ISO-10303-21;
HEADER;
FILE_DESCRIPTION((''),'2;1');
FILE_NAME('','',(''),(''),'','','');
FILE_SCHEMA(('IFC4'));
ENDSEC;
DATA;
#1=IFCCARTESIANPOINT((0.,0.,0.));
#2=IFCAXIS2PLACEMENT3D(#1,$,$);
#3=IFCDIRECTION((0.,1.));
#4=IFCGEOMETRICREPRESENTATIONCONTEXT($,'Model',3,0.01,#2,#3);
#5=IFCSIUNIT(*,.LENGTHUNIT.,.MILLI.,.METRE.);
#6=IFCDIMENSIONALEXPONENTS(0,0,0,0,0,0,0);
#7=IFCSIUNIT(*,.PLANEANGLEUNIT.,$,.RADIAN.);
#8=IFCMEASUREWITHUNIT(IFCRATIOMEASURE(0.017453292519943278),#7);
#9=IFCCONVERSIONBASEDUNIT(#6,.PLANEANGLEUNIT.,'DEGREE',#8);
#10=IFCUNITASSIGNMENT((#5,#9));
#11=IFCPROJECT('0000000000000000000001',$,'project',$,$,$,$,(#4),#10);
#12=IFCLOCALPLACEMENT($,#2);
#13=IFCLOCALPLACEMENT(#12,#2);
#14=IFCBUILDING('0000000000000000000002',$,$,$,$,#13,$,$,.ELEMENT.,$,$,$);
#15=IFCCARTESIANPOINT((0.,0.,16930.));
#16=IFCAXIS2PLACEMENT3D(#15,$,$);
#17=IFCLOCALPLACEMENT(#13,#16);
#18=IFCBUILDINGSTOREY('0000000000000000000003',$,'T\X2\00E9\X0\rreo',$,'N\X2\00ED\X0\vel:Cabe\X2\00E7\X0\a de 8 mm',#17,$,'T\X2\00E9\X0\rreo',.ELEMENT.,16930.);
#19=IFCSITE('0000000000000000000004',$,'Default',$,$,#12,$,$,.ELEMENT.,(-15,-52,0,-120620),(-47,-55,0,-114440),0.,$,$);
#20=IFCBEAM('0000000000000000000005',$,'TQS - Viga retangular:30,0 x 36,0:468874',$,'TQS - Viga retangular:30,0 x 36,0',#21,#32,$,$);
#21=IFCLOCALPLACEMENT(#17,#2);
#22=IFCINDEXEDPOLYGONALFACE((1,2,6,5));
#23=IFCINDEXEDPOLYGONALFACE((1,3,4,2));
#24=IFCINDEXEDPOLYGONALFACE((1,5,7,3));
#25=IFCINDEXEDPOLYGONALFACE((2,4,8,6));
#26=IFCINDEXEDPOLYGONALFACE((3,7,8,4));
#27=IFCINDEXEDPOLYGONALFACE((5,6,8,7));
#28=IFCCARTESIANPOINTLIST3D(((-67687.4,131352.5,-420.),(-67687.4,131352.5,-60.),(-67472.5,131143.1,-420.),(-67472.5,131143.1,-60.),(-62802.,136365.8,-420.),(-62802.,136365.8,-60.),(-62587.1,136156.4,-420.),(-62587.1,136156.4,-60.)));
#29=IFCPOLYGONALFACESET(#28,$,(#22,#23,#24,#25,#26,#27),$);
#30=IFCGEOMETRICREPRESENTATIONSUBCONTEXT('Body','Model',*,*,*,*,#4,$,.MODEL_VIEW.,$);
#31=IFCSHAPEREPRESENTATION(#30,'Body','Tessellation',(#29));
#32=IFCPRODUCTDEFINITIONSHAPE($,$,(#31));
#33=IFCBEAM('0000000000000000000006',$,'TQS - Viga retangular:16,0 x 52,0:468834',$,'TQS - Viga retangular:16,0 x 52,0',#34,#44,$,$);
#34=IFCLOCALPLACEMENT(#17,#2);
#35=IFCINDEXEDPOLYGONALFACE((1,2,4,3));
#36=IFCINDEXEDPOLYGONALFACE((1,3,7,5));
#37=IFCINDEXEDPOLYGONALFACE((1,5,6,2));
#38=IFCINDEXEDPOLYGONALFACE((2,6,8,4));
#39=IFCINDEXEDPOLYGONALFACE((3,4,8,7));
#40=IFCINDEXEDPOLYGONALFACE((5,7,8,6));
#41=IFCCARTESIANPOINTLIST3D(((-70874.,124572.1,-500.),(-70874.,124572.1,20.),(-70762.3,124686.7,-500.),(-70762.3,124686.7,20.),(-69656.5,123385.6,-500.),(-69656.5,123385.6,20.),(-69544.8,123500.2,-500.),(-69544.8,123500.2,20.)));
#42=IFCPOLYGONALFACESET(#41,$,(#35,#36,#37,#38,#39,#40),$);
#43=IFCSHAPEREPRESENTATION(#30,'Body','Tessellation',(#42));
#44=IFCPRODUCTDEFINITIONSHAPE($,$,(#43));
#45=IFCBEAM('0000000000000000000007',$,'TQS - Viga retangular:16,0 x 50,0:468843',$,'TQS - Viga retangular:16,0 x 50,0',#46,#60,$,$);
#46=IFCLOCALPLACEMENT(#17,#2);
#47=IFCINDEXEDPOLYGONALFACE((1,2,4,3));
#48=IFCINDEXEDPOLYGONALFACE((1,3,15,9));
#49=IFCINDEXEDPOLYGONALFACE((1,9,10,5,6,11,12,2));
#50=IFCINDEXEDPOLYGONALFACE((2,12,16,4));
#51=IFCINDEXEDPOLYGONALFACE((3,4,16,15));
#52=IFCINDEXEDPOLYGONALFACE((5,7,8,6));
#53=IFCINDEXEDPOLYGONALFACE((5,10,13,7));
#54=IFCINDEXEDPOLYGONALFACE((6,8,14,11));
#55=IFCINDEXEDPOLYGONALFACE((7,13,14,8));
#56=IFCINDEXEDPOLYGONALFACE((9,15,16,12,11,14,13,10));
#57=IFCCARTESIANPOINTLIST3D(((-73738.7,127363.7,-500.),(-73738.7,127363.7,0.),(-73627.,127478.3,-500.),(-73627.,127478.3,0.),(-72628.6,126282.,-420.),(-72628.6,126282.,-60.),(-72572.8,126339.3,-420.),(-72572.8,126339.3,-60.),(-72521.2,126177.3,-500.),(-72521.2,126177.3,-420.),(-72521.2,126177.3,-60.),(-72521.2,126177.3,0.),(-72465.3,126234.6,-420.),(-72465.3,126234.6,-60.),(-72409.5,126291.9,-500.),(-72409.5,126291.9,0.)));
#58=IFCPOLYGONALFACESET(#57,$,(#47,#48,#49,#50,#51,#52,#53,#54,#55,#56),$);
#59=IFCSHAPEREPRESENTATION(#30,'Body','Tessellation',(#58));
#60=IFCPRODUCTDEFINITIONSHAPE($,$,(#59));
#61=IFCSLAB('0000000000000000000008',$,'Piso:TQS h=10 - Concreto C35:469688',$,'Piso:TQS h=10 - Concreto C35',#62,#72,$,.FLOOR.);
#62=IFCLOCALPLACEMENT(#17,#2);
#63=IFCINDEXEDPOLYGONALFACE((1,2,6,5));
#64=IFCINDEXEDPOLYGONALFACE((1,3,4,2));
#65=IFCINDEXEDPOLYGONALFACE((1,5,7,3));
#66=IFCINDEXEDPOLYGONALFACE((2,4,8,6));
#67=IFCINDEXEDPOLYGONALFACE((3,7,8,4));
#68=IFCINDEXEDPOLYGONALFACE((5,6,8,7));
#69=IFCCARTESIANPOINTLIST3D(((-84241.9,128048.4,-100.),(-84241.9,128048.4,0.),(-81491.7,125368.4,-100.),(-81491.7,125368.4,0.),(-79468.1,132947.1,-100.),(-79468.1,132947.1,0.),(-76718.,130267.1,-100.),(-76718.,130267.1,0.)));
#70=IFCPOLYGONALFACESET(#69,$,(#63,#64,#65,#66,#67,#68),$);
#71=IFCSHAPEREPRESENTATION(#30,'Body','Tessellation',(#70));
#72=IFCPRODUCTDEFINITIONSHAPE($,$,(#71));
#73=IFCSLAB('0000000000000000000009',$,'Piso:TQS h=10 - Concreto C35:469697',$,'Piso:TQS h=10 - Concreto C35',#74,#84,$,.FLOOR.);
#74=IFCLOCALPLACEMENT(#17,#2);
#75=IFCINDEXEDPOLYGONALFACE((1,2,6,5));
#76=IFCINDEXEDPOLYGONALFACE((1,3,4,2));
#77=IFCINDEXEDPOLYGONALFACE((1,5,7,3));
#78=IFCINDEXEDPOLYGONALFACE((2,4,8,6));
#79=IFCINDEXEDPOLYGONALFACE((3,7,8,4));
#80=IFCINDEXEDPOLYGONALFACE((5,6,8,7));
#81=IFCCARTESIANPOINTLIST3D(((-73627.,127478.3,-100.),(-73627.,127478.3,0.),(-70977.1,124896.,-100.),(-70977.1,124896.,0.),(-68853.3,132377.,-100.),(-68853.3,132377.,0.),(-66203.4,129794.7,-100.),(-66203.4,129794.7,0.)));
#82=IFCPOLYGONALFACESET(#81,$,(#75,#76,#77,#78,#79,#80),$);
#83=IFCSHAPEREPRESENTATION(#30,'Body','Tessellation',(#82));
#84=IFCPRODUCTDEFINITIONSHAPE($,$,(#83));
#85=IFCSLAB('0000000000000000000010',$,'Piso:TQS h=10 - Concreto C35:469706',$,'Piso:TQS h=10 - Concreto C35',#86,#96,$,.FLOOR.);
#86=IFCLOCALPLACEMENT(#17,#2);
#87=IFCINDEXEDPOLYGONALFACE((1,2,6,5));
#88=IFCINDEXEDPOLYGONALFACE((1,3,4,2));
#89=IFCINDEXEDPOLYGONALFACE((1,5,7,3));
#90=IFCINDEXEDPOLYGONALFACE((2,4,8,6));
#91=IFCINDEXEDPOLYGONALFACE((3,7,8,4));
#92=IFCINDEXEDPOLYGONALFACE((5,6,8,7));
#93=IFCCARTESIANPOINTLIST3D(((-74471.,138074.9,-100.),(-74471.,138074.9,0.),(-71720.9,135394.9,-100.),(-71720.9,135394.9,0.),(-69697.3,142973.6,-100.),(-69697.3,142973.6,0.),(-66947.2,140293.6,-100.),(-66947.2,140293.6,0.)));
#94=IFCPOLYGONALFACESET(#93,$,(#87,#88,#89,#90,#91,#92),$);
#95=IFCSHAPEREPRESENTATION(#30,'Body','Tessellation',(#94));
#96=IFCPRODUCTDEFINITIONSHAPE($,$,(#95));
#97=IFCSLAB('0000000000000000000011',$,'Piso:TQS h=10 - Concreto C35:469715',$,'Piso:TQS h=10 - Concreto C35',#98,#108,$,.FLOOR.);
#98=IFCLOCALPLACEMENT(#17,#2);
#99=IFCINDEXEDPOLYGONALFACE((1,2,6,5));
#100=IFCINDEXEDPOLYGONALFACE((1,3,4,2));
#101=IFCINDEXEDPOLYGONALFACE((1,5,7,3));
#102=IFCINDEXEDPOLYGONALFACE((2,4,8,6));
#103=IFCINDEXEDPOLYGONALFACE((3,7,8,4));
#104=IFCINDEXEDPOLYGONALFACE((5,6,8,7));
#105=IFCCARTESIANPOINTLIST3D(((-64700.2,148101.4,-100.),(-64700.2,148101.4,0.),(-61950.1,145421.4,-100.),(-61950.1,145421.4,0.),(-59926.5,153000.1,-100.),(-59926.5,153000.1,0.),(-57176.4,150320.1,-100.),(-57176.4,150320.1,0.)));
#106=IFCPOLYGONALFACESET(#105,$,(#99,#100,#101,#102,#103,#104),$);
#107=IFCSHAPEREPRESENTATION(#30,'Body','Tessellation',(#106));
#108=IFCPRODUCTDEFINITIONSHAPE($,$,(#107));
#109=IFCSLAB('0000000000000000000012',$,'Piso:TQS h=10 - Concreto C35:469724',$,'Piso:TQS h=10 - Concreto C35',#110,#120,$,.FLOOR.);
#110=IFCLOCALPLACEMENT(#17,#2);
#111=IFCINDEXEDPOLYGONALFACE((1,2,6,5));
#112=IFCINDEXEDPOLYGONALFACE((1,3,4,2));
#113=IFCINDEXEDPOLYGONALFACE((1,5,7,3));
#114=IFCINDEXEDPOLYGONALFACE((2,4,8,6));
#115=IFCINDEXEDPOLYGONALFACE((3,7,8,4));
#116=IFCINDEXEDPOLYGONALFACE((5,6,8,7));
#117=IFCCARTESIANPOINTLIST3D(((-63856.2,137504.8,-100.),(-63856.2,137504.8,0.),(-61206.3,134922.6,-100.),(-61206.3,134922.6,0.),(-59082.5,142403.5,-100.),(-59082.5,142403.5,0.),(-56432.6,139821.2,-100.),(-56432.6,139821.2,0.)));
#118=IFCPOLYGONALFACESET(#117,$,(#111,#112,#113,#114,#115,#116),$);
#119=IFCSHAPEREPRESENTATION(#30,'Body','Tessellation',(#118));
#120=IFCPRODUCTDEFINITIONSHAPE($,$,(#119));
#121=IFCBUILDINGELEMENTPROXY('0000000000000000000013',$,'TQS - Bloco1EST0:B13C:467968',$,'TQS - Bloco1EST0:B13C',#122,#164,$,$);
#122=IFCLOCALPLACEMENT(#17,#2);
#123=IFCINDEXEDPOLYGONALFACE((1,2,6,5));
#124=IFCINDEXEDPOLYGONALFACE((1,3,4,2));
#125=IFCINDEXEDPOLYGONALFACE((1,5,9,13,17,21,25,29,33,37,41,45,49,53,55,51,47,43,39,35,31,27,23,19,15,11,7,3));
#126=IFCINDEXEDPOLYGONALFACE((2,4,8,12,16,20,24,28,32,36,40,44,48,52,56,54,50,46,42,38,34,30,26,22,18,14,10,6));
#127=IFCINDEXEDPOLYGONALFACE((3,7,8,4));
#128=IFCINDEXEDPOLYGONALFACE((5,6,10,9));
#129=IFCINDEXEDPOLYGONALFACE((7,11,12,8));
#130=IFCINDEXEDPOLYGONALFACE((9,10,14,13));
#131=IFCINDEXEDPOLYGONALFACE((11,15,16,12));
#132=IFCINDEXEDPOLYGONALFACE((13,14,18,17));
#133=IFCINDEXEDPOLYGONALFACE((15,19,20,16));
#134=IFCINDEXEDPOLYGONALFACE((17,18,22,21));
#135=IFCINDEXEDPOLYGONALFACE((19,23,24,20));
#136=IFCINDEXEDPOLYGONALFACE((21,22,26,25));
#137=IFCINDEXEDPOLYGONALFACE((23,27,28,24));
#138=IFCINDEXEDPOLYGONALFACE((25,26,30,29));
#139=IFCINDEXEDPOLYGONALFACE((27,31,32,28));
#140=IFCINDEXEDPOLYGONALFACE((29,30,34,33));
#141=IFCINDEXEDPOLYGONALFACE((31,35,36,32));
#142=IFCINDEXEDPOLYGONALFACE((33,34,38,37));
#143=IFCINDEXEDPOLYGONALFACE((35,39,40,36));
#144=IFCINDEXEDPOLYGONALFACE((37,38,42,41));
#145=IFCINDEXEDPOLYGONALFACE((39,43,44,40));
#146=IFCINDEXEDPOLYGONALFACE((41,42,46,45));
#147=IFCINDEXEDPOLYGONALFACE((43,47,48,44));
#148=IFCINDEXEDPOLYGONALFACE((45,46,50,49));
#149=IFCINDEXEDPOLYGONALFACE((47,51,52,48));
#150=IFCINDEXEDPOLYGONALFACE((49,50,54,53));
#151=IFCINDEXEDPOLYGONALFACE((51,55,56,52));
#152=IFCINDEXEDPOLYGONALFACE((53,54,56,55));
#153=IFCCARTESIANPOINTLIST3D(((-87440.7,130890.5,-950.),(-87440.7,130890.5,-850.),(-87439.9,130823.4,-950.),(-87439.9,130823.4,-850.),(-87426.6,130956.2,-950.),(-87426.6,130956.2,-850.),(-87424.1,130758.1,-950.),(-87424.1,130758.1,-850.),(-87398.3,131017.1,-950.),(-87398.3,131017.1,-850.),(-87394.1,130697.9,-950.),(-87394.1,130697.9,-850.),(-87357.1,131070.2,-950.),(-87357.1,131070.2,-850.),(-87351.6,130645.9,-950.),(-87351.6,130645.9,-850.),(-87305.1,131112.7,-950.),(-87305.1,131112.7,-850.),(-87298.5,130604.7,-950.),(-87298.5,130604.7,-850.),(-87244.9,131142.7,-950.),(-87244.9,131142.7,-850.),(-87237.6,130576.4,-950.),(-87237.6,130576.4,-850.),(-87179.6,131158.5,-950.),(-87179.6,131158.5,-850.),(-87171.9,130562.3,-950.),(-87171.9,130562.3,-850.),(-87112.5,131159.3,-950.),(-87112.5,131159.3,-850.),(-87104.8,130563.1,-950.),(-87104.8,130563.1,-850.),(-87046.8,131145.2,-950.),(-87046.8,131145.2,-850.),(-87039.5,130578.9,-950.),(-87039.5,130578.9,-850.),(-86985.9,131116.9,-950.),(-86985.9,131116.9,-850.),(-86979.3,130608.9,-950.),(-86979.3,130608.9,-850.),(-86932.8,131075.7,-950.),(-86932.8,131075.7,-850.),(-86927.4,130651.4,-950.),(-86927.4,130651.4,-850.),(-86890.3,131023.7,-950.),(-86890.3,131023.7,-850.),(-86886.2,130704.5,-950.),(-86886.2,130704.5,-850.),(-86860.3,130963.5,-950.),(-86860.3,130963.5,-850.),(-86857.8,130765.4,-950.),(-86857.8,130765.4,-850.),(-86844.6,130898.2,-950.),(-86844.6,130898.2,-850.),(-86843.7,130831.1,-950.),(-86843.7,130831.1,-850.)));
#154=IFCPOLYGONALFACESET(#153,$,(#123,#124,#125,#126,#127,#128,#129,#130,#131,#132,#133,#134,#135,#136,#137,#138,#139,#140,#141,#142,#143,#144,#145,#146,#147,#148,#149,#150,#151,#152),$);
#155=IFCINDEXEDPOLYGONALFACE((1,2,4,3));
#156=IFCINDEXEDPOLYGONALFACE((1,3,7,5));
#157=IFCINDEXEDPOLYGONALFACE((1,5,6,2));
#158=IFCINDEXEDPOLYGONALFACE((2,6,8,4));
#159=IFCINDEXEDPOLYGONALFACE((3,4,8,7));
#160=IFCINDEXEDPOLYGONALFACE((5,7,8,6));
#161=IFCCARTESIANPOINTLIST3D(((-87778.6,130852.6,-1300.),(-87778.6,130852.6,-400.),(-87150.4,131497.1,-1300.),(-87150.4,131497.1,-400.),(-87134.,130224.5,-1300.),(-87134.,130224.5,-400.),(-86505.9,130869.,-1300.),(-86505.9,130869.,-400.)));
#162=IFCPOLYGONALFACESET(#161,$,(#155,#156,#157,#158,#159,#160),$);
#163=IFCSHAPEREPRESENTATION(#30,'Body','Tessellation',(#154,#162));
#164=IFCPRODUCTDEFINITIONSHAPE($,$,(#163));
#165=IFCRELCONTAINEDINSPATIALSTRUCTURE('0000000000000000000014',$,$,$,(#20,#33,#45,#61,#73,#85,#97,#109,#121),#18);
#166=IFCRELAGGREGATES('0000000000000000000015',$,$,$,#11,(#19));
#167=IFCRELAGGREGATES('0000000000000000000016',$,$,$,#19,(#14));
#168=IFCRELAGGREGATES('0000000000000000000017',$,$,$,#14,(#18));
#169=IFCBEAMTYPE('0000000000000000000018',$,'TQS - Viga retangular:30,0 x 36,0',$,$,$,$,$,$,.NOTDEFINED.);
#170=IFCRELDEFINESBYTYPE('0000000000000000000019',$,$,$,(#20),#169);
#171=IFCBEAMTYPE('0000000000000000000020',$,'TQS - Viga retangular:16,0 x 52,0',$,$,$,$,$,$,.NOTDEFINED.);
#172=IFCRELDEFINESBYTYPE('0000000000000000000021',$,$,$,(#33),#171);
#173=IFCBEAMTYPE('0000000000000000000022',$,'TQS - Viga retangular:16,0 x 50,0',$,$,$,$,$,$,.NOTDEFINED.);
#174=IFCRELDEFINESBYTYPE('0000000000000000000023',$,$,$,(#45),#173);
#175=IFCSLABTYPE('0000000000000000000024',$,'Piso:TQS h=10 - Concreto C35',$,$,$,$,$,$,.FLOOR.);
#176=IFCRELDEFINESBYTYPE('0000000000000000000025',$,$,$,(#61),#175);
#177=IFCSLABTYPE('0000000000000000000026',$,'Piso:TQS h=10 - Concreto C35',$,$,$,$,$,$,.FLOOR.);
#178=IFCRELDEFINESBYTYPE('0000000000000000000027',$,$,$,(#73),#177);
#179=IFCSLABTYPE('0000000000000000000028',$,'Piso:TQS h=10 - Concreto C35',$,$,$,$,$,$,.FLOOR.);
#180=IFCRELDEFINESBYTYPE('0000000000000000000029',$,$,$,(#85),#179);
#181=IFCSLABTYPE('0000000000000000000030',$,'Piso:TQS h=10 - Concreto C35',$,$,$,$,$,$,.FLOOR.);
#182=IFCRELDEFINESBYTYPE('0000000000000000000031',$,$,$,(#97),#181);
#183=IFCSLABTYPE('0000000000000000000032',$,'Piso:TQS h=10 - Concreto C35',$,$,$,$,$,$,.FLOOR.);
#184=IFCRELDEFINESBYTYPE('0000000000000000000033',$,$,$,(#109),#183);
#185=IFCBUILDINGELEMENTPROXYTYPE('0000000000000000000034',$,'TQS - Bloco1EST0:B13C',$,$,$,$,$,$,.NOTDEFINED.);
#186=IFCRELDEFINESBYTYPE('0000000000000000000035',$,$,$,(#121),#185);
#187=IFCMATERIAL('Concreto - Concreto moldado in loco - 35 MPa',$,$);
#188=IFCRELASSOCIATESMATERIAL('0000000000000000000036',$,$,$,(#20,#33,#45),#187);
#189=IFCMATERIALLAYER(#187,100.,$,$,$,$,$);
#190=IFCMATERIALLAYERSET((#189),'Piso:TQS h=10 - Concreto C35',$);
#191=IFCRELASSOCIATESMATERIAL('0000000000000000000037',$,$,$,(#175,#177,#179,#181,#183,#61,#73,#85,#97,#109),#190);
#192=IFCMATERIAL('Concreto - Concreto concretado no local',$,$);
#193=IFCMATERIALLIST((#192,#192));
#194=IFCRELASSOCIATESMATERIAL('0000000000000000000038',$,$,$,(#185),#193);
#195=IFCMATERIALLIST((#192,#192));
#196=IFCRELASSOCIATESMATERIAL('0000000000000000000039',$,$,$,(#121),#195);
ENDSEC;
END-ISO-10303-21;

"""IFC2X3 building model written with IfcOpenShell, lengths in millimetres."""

from ifc_helpers import new_model, entity, si_unit, converted_unit, direction, frame, frame_2d, origin, origin_2d_with_axis, place, context, subcontext, project, spatial, polyline, rectangle, circle, extrude, boolean, clip, bounded_halfspace, source, transform, mapped, material, material_list, layer, layer_set, layer_usage, type_object, type_shapes, element, save


model = new_model("IFC2X3")

# Units and contexts
model_context = context("Model", 3, precision=0.01, world=origin(), true_north=direction((0.0, 1.0)))
body_context = subcontext(model_context, "Body", "Model", "MODEL_VIEW")
ifc_project = project(units=[si_unit("LENGTHUNIT", "METRE", prefix="MILLI"), converted_unit("PLANEANGLEUNIT", "DEGREE", entity("IfcRatioMeasure", 0.017453292519943278), si_unit("PLANEANGLEUNIT", "RADIAN"), dimensions=[0, 0, 0, 0, 0, 0, 0])], contexts=[model_context])

# Site, building, storey
site_placement = place(None, origin())
site = spatial("IfcSite", under=ifc_project, at=site_placement, Name="Default", CompositionType="ELEMENT", RefLatitude=(-15, -52, 0, -120620), RefLongitude=(-47, -55, 0, -114440), RefElevation=0.0)
building_placement = place(site_placement, origin())
building = spatial("IfcBuilding", under=site, at=building_placement, CompositionType="ELEMENT")
storey_placement = place(building_placement, frame((0.0, 0.0, 16930.0)))
storey = spatial("IfcBuildingStorey", under=building, at=storey_placement, Name="Térreo", ObjectType="Nível:Cabeça de 8 mm", LongName="Térreo", CompositionType="ELEMENT", Elevation=16930.0)

# Beams
ifc_material_1 = material(Name="Concreto - Concreto moldado in loco - 35 MPa")
beam_type_1 = type_object("IfcBeamType", Name="TQS - Viga retangular:30,0 x 36,0", PredefinedType="NOTDEFINED")
beam_1_placement = place(storey_placement, frame((-67579.9, 131247.8, -60.0), z_axis=(0.0, 0.0, 1.0), x_axis=(0.697915, 0.71618, 0.0)))
element("IfcBeam", 1, at=beam_1_placement, inside=storey, type_object=beam_type_1, material=ifc_material_1, Name="TQS - Viga retangular:30,0 x 36,0:468874", ObjectType="TQS - Viga retangular:30,0 x 36,0", context=body_context, shape_type="SweptSolid", body=[
    extrude(rectangle(XDim=360.0, YDim=300.0, at=frame_2d((0.0, 0.0), x_axis=(1.0, 0.0))), frame((0.0, 0.0, -180.0), z_axis=(1.0, 0.0, 0.0), x_axis=(0.0, 0.0, -1.0)), (0.0, 0.0, 1.0), 7000.0),
])
beam_type_2 = type_object("IfcBeamType", Name="TQS - Viga retangular:16,0 x 52,0", PredefinedType="NOTDEFINED")
beam_2_placement = place(storey_placement, frame((-69600.6, 123442.9, 20.0), z_axis=(0.0, 0.0, 1.0), x_axis=(-0.71618, 0.697915, 0.0)))
element("IfcBeam", 2, at=beam_2_placement, inside=storey, type_object=beam_type_2, material=ifc_material_1, Name="TQS - Viga retangular:16,0 x 52,0:468834", ObjectType="TQS - Viga retangular:16,0 x 52,0", context=body_context, shape_type="SweptSolid", body=[
    extrude(rectangle(XDim=520.0, YDim=160.0, at=frame_2d((0.0, 0.0), x_axis=(1.0, 0.0))), frame((0.0, 0.0, -260.0), z_axis=(1.0, 0.0, 0.0), x_axis=(0.0, 0.0, -1.0)), (0.0, 0.0, 1.0), 1700.0),
])
beam_type_3 = type_object("IfcBeamType", Name="TQS - Viga retangular:16,0 x 50,0", PredefinedType="NOTDEFINED")
beam_3_placement = place(storey_placement, frame((-72465.3, 126234.6, 0.0), z_axis=(0.0, 0.0, 1.0), x_axis=(-0.71618, 0.697915, 0.0)))
element("IfcBeam", 3, at=beam_3_placement, inside=storey, type_object=beam_type_3, material=ifc_material_1, Name="TQS - Viga retangular:16,0 x 50,0:468843", ObjectType="TQS - Viga retangular:16,0 x 50,0", context=body_context, shape_type="SweptSolid", body=[
    boolean("DIFFERENCE", clip(extrude(rectangle(XDim=500.0, YDim=160.0, at=frame_2d((0.0, 0.0), x_axis=(1.0, 0.0))), frame((0.0, 0.0, -250.0), z_axis=(1.0, 0.0, 0.0), x_axis=(0.0, 0.0, -1.0)), (0.0, 0.0, 1.0), 1700.0), bounded_halfspace(frame((150.0, 0.0, -420.0), z_axis=(-1.0, 0.0, 0.0), x_axis=(0.0, 1.0, 0.0)), False, frame((0.0, 0.0, -250.0), z_axis=(1.0, 0.0, 0.0), x_axis=(0.0, 0.0, -1.0)), polyline([(170.0, 0.0), (-190.0, 0.0), (-190.0, 80.0), (-90.0, 80.0), (170.0, 80.0), (170.0, 0.0)]))), extrude(rectangle(XDim=360.0, YDim=80.0, at=frame_2d((0.0, 0.0), x_axis=(0.0, 1.0))), frame((0.0, 40.0, -240.0), z_axis=(-1.0, 0.0, 0.0), x_axis=(0.0, -1.0, 0.0)), (0.0, 0.0, -1.0), 150.0)),
])

# Slabs
ifc_layer = layer(ifc_material_1, 100.0)
ifc_layer_set = layer_set([ifc_layer], Name="Piso:TQS h=10 - Concreto C35")
ifc_layer_usage_1 = layer_usage(ifc_layer_set, "AXIS3", "POSITIVE", 0.0)
slab_type_1 = type_object("IfcSlabType", Name="Piso:TQS h=10 - Concreto C35", PredefinedType="FLOOR", material=ifc_layer_set)
slab_1_placement = place(storey_placement, origin())
element("IfcSlab", 4, at=slab_1_placement, inside=storey, type_object=slab_type_1, material=ifc_layer_usage_1, Name="Piso:TQS h=10 - Concreto C35:469688", ObjectType="Piso:TQS h=10 - Concreto C35", PredefinedType="FLOOR", context=body_context, shape_type="SweptSolid", body=[
    extrude(rectangle(XDim=6840.0, YDim=3840.0, at=frame_2d((0.0, 0.0), x_axis=(1.0, 0.0))), frame((-80479.9, 129157.7, 0.0), z_axis=(0.0, 0.0, -1.0), x_axis=(-0.697915, -0.71618, 0.0)), (0.0, 0.0, 1.0), 100.0),
])
ifc_layer_usage_2 = layer_usage(ifc_layer_set, "AXIS3", "POSITIVE", 0.0)
slab_type_2 = type_object("IfcSlabType", Name="Piso:TQS h=10 - Concreto C35", PredefinedType="FLOOR", material=ifc_layer_set)
slab_2_placement = place(storey_placement, origin())
element("IfcSlab", 5, at=slab_2_placement, inside=storey, type_object=slab_type_2, material=ifc_layer_usage_2, Name="Piso:TQS h=10 - Concreto C35:469697", ObjectType="Piso:TQS h=10 - Concreto C35", PredefinedType="FLOOR", context=body_context, shape_type="SweptSolid", body=[
    extrude(rectangle(XDim=6840.0, YDim=3700.0, at=origin_2d_with_axis()), frame((-69915.2, 128636.5, 0.0), z_axis=(0.0, 0.0, -1.0), x_axis=(-0.697915, -0.71618, 0.0)), (0.0, 0.0, 1.0), 100.0),
])
ifc_layer_usage_3 = layer_usage(ifc_layer_set, "AXIS3", "POSITIVE", 0.0)
slab_type_3 = type_object("IfcSlabType", Name="Piso:TQS h=10 - Concreto C35", PredefinedType="FLOOR", material=ifc_layer_set)
slab_3_placement = place(storey_placement, origin())
element("IfcSlab", 6, at=slab_3_placement, inside=storey, type_object=slab_type_3, material=ifc_layer_usage_3, Name="Piso:TQS h=10 - Concreto C35:469706", ObjectType="Piso:TQS h=10 - Concreto C35", PredefinedType="FLOOR", context=body_context, shape_type="SweptSolid", body=[
    extrude(rectangle(XDim=3840.0, YDim=6840.0, at=origin_2d_with_axis()), frame((-70709.1, 139184.2, 0.0), z_axis=(0.0, 0.0, -1.0), x_axis=(0.71618, -0.697915, 0.0)), (0.0, 0.0, 1.0), 100.0),
])
ifc_layer_usage_4 = layer_usage(ifc_layer_set, "AXIS3", "POSITIVE", 0.0)
slab_type_4 = type_object("IfcSlabType", Name="Piso:TQS h=10 - Concreto C35", PredefinedType="FLOOR", material=ifc_layer_set)
slab_4_placement = place(storey_placement, origin())
element("IfcSlab", 7, at=slab_4_placement, inside=storey, type_object=slab_type_4, material=ifc_layer_usage_4, Name="Piso:TQS h=10 - Concreto C35:469715", ObjectType="Piso:TQS h=10 - Concreto C35", PredefinedType="FLOOR", context=body_context, shape_type="SweptSolid", body=[
    extrude(rectangle(XDim=3840.0, YDim=6840.0, at=frame_2d((0.0, 0.0), x_axis=(1.0, 0.0))), frame((-60938.3, 149210.8, 0.0), z_axis=(0.0, 0.0, -1.0), x_axis=(0.71618, -0.697915, 0.0)), (0.0, 0.0, 1.0), 100.0),
])
ifc_layer_usage_5 = layer_usage(ifc_layer_set, "AXIS3", "POSITIVE", 0.0)
slab_type_5 = type_object("IfcSlabType", Name="Piso:TQS h=10 - Concreto C35", PredefinedType="FLOOR", material=ifc_layer_set)
slab_5_placement = place(storey_placement, origin())
element("IfcSlab", 8, at=slab_5_placement, inside=storey, type_object=slab_type_5, material=ifc_layer_usage_5, Name="Piso:TQS h=10 - Concreto C35:469724", ObjectType="Piso:TQS h=10 - Concreto C35", PredefinedType="FLOOR", context=body_context, shape_type="SweptSolid", body=[
    extrude(rectangle(XDim=6840.0, YDim=3700.0, at=frame_2d((0.0, 0.0), x_axis=(1.0, 0.0))), frame((-60144.4, 138663.0, 0.0), z_axis=(0.0, 0.0, -1.0), x_axis=(-0.697915, -0.71618, 0.0)), (0.0, 0.0, 1.0), 100.0),
])

# Building element proxy
ifc_material_2 = material(Name="Concreto - Concreto concretado no local")
ifc_material_list_1 = material_list([ifc_material_2, ifc_material_2])
ifc_material_list_2 = material_list([ifc_material_2, ifc_material_2])
building_element_proxy_type_1 = type_object("IfcBuildingElementProxyType", Name="TQS - Bloco1EST0:B13C", PredefinedType="NOTDEFINED", material=ifc_material_list_2)
shared_shape_1 = source(origin(), body_context, "Body", "SweptSolid", [
    extrude(circle(Radius=300.0, at=frame_2d((0.0, 0.0), x_axis=(1.0, 0.0))), frame((0.0, 0.0, -550.0)), (0.0, 0.0, 1.0), 100.0),
    extrude(rectangle(XDim=900.0, YDim=900.0, at=origin_2d_with_axis()), frame((0.0, 0.0, -900.0), z_axis=(0.0, 0.0, 1.0), x_axis=(-1.0, 0.0, 0.0)), (0.0, 0.0, 1.0), 900.0),
])
type_shapes(building_element_proxy_type_1, [shared_shape_1])
proxy_1_placement = place(storey_placement, frame((-87142.2, 130860.8, -400.0), z_axis=(0.0, 0.0, 1.0), x_axis=(0.697915, 0.71618, 0.0)))
element("IfcBuildingElementProxy", 9, at=proxy_1_placement, inside=storey, type_object=building_element_proxy_type_1, material=ifc_material_list_1, Name="TQS - Bloco1EST0:B13C:467968", ObjectType="TQS - Bloco1EST0:B13C", context=body_context, shape_type="MappedRepresentation", body=[
    mapped(shared_shape_1, transform((0.0, 0.0, 0.0), scale=1.0)),
])

save(model, "model.ifc")
